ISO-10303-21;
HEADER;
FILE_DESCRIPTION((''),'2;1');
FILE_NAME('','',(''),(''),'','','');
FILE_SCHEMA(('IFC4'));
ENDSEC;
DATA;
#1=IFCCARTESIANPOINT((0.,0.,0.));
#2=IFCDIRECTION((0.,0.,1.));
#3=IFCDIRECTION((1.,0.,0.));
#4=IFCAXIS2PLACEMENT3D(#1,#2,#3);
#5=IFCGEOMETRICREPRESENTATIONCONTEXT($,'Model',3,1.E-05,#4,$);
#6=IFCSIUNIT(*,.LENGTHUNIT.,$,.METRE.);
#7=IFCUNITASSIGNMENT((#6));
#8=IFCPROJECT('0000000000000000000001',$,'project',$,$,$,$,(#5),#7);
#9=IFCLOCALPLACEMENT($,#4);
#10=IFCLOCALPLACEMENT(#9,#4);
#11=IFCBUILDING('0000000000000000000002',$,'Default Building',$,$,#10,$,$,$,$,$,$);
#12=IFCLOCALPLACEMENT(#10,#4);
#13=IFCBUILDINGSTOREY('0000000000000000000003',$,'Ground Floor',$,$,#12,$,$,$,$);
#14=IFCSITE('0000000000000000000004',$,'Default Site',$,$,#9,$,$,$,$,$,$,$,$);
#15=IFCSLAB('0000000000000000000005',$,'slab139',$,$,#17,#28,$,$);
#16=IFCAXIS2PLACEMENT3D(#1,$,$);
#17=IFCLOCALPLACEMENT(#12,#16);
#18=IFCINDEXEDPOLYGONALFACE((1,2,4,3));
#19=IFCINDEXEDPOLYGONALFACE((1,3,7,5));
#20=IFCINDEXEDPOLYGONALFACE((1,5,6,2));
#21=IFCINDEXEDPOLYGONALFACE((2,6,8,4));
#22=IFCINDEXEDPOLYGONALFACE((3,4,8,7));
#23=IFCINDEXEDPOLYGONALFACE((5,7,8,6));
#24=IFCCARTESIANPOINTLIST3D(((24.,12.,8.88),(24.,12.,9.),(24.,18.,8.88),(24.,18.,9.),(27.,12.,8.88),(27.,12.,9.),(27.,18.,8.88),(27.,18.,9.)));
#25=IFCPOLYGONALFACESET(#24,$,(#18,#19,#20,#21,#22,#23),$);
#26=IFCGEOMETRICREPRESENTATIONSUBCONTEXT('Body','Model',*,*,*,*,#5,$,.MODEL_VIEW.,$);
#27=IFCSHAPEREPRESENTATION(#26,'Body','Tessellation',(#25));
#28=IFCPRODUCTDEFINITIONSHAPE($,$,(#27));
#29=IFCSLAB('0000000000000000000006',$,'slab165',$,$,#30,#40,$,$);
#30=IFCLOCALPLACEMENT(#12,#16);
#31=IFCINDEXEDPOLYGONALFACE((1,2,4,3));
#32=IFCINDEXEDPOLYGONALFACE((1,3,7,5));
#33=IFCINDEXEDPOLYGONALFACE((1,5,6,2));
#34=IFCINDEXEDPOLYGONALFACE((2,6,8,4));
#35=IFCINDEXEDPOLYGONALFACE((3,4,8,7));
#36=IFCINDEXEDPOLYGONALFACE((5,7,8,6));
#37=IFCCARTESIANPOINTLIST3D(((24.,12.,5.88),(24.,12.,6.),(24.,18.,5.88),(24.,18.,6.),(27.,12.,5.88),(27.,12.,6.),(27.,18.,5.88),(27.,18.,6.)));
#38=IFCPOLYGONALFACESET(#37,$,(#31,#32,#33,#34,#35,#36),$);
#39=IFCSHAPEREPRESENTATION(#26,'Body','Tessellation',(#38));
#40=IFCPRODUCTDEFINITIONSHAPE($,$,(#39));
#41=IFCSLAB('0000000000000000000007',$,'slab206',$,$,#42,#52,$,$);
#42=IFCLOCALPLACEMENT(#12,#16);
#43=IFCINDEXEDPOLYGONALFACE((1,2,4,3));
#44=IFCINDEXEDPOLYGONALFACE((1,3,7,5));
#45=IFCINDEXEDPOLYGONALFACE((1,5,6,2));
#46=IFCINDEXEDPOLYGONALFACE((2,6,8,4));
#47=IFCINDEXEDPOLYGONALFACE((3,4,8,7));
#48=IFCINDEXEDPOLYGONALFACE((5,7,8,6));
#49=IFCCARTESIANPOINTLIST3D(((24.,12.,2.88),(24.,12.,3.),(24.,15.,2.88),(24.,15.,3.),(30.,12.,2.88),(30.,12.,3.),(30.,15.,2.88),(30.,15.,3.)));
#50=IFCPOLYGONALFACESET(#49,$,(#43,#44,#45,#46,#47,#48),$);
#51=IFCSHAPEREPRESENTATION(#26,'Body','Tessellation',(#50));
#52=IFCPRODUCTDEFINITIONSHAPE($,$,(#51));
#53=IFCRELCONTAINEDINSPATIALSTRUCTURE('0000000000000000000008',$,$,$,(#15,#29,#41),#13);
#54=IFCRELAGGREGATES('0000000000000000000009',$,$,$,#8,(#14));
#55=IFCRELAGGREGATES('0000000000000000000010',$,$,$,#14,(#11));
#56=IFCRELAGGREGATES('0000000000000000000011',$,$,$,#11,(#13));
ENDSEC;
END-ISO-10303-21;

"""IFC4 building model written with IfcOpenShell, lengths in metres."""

from ifc_helpers import new_model, si_unit, frame, origin_with_axes, place, context, subcontext, project, spatial, indexed_curve, outline, extrude, element, save


model = new_model("IFC4")

# Units and contexts
model_context = context("Model", 3, precision=1e-05, world=origin_with_axes())
body_context = subcontext(model_context, "Body", "Model", "MODEL_VIEW")
ifc_project = project(units=[si_unit("LENGTHUNIT", "METRE")], contexts=[model_context])

# Site, building, storey
site_placement = place(None, origin_with_axes())
site = spatial("IfcSite", under=ifc_project, at=site_placement, Name="Default Site")
building_placement = place(site_placement, origin_with_axes())
building = spatial("IfcBuilding", under=site, at=building_placement, Name="Default Building")
storey_placement = place(building_placement, origin_with_axes())
storey = spatial("IfcBuildingStorey", under=building, at=storey_placement, Name="Ground Floor")

# Slabs
for number, where, z_axis, x_axis, name in (
    (1, (24.0, 12.0, 8.88), (0.0, 0.0, 1.0), (1.0, 0.0, 0.0), "slab139"),
    (2, (24.0, 12.0, 5.88), (0.0, 0.0, 1.0), (1.0, 0.0, 0.0), "slab165"),
):
    element("IfcSlab", number, at=place(storey_placement, frame(where, z_axis=z_axis, x_axis=x_axis)), inside=storey, Name=name, context=body_context, shape_type="SweptSolid", body=[
        extrude(outline(indexed_curve([(0.0, 0.0), (0.0, 6.0), (3.0, 6.0), (3.0, 0.0), (0.0, 0.0)], self_intersect=False)), origin_with_axes(), (0.0, 0.0, 1.0), 0.12),
    ])
slab_placement = place(storey_placement, frame((24.0, 12.0, 2.88), z_axis=(0.0, 0.0, 1.0), x_axis=(1.0, 0.0, 0.0)))
element("IfcSlab", 3, at=slab_placement, inside=storey, Name="slab206", context=body_context, shape_type="SweptSolid", body=[
    extrude(outline(indexed_curve([(0.0, 0.0), (0.0, 3.0), (6.0, 3.0), (6.0, 0.0), (0.0, 0.0)], self_intersect=False)), origin_with_axes(), (0.0, 0.0, 1.0), 0.12),
])

save(model, "model.ifc")
